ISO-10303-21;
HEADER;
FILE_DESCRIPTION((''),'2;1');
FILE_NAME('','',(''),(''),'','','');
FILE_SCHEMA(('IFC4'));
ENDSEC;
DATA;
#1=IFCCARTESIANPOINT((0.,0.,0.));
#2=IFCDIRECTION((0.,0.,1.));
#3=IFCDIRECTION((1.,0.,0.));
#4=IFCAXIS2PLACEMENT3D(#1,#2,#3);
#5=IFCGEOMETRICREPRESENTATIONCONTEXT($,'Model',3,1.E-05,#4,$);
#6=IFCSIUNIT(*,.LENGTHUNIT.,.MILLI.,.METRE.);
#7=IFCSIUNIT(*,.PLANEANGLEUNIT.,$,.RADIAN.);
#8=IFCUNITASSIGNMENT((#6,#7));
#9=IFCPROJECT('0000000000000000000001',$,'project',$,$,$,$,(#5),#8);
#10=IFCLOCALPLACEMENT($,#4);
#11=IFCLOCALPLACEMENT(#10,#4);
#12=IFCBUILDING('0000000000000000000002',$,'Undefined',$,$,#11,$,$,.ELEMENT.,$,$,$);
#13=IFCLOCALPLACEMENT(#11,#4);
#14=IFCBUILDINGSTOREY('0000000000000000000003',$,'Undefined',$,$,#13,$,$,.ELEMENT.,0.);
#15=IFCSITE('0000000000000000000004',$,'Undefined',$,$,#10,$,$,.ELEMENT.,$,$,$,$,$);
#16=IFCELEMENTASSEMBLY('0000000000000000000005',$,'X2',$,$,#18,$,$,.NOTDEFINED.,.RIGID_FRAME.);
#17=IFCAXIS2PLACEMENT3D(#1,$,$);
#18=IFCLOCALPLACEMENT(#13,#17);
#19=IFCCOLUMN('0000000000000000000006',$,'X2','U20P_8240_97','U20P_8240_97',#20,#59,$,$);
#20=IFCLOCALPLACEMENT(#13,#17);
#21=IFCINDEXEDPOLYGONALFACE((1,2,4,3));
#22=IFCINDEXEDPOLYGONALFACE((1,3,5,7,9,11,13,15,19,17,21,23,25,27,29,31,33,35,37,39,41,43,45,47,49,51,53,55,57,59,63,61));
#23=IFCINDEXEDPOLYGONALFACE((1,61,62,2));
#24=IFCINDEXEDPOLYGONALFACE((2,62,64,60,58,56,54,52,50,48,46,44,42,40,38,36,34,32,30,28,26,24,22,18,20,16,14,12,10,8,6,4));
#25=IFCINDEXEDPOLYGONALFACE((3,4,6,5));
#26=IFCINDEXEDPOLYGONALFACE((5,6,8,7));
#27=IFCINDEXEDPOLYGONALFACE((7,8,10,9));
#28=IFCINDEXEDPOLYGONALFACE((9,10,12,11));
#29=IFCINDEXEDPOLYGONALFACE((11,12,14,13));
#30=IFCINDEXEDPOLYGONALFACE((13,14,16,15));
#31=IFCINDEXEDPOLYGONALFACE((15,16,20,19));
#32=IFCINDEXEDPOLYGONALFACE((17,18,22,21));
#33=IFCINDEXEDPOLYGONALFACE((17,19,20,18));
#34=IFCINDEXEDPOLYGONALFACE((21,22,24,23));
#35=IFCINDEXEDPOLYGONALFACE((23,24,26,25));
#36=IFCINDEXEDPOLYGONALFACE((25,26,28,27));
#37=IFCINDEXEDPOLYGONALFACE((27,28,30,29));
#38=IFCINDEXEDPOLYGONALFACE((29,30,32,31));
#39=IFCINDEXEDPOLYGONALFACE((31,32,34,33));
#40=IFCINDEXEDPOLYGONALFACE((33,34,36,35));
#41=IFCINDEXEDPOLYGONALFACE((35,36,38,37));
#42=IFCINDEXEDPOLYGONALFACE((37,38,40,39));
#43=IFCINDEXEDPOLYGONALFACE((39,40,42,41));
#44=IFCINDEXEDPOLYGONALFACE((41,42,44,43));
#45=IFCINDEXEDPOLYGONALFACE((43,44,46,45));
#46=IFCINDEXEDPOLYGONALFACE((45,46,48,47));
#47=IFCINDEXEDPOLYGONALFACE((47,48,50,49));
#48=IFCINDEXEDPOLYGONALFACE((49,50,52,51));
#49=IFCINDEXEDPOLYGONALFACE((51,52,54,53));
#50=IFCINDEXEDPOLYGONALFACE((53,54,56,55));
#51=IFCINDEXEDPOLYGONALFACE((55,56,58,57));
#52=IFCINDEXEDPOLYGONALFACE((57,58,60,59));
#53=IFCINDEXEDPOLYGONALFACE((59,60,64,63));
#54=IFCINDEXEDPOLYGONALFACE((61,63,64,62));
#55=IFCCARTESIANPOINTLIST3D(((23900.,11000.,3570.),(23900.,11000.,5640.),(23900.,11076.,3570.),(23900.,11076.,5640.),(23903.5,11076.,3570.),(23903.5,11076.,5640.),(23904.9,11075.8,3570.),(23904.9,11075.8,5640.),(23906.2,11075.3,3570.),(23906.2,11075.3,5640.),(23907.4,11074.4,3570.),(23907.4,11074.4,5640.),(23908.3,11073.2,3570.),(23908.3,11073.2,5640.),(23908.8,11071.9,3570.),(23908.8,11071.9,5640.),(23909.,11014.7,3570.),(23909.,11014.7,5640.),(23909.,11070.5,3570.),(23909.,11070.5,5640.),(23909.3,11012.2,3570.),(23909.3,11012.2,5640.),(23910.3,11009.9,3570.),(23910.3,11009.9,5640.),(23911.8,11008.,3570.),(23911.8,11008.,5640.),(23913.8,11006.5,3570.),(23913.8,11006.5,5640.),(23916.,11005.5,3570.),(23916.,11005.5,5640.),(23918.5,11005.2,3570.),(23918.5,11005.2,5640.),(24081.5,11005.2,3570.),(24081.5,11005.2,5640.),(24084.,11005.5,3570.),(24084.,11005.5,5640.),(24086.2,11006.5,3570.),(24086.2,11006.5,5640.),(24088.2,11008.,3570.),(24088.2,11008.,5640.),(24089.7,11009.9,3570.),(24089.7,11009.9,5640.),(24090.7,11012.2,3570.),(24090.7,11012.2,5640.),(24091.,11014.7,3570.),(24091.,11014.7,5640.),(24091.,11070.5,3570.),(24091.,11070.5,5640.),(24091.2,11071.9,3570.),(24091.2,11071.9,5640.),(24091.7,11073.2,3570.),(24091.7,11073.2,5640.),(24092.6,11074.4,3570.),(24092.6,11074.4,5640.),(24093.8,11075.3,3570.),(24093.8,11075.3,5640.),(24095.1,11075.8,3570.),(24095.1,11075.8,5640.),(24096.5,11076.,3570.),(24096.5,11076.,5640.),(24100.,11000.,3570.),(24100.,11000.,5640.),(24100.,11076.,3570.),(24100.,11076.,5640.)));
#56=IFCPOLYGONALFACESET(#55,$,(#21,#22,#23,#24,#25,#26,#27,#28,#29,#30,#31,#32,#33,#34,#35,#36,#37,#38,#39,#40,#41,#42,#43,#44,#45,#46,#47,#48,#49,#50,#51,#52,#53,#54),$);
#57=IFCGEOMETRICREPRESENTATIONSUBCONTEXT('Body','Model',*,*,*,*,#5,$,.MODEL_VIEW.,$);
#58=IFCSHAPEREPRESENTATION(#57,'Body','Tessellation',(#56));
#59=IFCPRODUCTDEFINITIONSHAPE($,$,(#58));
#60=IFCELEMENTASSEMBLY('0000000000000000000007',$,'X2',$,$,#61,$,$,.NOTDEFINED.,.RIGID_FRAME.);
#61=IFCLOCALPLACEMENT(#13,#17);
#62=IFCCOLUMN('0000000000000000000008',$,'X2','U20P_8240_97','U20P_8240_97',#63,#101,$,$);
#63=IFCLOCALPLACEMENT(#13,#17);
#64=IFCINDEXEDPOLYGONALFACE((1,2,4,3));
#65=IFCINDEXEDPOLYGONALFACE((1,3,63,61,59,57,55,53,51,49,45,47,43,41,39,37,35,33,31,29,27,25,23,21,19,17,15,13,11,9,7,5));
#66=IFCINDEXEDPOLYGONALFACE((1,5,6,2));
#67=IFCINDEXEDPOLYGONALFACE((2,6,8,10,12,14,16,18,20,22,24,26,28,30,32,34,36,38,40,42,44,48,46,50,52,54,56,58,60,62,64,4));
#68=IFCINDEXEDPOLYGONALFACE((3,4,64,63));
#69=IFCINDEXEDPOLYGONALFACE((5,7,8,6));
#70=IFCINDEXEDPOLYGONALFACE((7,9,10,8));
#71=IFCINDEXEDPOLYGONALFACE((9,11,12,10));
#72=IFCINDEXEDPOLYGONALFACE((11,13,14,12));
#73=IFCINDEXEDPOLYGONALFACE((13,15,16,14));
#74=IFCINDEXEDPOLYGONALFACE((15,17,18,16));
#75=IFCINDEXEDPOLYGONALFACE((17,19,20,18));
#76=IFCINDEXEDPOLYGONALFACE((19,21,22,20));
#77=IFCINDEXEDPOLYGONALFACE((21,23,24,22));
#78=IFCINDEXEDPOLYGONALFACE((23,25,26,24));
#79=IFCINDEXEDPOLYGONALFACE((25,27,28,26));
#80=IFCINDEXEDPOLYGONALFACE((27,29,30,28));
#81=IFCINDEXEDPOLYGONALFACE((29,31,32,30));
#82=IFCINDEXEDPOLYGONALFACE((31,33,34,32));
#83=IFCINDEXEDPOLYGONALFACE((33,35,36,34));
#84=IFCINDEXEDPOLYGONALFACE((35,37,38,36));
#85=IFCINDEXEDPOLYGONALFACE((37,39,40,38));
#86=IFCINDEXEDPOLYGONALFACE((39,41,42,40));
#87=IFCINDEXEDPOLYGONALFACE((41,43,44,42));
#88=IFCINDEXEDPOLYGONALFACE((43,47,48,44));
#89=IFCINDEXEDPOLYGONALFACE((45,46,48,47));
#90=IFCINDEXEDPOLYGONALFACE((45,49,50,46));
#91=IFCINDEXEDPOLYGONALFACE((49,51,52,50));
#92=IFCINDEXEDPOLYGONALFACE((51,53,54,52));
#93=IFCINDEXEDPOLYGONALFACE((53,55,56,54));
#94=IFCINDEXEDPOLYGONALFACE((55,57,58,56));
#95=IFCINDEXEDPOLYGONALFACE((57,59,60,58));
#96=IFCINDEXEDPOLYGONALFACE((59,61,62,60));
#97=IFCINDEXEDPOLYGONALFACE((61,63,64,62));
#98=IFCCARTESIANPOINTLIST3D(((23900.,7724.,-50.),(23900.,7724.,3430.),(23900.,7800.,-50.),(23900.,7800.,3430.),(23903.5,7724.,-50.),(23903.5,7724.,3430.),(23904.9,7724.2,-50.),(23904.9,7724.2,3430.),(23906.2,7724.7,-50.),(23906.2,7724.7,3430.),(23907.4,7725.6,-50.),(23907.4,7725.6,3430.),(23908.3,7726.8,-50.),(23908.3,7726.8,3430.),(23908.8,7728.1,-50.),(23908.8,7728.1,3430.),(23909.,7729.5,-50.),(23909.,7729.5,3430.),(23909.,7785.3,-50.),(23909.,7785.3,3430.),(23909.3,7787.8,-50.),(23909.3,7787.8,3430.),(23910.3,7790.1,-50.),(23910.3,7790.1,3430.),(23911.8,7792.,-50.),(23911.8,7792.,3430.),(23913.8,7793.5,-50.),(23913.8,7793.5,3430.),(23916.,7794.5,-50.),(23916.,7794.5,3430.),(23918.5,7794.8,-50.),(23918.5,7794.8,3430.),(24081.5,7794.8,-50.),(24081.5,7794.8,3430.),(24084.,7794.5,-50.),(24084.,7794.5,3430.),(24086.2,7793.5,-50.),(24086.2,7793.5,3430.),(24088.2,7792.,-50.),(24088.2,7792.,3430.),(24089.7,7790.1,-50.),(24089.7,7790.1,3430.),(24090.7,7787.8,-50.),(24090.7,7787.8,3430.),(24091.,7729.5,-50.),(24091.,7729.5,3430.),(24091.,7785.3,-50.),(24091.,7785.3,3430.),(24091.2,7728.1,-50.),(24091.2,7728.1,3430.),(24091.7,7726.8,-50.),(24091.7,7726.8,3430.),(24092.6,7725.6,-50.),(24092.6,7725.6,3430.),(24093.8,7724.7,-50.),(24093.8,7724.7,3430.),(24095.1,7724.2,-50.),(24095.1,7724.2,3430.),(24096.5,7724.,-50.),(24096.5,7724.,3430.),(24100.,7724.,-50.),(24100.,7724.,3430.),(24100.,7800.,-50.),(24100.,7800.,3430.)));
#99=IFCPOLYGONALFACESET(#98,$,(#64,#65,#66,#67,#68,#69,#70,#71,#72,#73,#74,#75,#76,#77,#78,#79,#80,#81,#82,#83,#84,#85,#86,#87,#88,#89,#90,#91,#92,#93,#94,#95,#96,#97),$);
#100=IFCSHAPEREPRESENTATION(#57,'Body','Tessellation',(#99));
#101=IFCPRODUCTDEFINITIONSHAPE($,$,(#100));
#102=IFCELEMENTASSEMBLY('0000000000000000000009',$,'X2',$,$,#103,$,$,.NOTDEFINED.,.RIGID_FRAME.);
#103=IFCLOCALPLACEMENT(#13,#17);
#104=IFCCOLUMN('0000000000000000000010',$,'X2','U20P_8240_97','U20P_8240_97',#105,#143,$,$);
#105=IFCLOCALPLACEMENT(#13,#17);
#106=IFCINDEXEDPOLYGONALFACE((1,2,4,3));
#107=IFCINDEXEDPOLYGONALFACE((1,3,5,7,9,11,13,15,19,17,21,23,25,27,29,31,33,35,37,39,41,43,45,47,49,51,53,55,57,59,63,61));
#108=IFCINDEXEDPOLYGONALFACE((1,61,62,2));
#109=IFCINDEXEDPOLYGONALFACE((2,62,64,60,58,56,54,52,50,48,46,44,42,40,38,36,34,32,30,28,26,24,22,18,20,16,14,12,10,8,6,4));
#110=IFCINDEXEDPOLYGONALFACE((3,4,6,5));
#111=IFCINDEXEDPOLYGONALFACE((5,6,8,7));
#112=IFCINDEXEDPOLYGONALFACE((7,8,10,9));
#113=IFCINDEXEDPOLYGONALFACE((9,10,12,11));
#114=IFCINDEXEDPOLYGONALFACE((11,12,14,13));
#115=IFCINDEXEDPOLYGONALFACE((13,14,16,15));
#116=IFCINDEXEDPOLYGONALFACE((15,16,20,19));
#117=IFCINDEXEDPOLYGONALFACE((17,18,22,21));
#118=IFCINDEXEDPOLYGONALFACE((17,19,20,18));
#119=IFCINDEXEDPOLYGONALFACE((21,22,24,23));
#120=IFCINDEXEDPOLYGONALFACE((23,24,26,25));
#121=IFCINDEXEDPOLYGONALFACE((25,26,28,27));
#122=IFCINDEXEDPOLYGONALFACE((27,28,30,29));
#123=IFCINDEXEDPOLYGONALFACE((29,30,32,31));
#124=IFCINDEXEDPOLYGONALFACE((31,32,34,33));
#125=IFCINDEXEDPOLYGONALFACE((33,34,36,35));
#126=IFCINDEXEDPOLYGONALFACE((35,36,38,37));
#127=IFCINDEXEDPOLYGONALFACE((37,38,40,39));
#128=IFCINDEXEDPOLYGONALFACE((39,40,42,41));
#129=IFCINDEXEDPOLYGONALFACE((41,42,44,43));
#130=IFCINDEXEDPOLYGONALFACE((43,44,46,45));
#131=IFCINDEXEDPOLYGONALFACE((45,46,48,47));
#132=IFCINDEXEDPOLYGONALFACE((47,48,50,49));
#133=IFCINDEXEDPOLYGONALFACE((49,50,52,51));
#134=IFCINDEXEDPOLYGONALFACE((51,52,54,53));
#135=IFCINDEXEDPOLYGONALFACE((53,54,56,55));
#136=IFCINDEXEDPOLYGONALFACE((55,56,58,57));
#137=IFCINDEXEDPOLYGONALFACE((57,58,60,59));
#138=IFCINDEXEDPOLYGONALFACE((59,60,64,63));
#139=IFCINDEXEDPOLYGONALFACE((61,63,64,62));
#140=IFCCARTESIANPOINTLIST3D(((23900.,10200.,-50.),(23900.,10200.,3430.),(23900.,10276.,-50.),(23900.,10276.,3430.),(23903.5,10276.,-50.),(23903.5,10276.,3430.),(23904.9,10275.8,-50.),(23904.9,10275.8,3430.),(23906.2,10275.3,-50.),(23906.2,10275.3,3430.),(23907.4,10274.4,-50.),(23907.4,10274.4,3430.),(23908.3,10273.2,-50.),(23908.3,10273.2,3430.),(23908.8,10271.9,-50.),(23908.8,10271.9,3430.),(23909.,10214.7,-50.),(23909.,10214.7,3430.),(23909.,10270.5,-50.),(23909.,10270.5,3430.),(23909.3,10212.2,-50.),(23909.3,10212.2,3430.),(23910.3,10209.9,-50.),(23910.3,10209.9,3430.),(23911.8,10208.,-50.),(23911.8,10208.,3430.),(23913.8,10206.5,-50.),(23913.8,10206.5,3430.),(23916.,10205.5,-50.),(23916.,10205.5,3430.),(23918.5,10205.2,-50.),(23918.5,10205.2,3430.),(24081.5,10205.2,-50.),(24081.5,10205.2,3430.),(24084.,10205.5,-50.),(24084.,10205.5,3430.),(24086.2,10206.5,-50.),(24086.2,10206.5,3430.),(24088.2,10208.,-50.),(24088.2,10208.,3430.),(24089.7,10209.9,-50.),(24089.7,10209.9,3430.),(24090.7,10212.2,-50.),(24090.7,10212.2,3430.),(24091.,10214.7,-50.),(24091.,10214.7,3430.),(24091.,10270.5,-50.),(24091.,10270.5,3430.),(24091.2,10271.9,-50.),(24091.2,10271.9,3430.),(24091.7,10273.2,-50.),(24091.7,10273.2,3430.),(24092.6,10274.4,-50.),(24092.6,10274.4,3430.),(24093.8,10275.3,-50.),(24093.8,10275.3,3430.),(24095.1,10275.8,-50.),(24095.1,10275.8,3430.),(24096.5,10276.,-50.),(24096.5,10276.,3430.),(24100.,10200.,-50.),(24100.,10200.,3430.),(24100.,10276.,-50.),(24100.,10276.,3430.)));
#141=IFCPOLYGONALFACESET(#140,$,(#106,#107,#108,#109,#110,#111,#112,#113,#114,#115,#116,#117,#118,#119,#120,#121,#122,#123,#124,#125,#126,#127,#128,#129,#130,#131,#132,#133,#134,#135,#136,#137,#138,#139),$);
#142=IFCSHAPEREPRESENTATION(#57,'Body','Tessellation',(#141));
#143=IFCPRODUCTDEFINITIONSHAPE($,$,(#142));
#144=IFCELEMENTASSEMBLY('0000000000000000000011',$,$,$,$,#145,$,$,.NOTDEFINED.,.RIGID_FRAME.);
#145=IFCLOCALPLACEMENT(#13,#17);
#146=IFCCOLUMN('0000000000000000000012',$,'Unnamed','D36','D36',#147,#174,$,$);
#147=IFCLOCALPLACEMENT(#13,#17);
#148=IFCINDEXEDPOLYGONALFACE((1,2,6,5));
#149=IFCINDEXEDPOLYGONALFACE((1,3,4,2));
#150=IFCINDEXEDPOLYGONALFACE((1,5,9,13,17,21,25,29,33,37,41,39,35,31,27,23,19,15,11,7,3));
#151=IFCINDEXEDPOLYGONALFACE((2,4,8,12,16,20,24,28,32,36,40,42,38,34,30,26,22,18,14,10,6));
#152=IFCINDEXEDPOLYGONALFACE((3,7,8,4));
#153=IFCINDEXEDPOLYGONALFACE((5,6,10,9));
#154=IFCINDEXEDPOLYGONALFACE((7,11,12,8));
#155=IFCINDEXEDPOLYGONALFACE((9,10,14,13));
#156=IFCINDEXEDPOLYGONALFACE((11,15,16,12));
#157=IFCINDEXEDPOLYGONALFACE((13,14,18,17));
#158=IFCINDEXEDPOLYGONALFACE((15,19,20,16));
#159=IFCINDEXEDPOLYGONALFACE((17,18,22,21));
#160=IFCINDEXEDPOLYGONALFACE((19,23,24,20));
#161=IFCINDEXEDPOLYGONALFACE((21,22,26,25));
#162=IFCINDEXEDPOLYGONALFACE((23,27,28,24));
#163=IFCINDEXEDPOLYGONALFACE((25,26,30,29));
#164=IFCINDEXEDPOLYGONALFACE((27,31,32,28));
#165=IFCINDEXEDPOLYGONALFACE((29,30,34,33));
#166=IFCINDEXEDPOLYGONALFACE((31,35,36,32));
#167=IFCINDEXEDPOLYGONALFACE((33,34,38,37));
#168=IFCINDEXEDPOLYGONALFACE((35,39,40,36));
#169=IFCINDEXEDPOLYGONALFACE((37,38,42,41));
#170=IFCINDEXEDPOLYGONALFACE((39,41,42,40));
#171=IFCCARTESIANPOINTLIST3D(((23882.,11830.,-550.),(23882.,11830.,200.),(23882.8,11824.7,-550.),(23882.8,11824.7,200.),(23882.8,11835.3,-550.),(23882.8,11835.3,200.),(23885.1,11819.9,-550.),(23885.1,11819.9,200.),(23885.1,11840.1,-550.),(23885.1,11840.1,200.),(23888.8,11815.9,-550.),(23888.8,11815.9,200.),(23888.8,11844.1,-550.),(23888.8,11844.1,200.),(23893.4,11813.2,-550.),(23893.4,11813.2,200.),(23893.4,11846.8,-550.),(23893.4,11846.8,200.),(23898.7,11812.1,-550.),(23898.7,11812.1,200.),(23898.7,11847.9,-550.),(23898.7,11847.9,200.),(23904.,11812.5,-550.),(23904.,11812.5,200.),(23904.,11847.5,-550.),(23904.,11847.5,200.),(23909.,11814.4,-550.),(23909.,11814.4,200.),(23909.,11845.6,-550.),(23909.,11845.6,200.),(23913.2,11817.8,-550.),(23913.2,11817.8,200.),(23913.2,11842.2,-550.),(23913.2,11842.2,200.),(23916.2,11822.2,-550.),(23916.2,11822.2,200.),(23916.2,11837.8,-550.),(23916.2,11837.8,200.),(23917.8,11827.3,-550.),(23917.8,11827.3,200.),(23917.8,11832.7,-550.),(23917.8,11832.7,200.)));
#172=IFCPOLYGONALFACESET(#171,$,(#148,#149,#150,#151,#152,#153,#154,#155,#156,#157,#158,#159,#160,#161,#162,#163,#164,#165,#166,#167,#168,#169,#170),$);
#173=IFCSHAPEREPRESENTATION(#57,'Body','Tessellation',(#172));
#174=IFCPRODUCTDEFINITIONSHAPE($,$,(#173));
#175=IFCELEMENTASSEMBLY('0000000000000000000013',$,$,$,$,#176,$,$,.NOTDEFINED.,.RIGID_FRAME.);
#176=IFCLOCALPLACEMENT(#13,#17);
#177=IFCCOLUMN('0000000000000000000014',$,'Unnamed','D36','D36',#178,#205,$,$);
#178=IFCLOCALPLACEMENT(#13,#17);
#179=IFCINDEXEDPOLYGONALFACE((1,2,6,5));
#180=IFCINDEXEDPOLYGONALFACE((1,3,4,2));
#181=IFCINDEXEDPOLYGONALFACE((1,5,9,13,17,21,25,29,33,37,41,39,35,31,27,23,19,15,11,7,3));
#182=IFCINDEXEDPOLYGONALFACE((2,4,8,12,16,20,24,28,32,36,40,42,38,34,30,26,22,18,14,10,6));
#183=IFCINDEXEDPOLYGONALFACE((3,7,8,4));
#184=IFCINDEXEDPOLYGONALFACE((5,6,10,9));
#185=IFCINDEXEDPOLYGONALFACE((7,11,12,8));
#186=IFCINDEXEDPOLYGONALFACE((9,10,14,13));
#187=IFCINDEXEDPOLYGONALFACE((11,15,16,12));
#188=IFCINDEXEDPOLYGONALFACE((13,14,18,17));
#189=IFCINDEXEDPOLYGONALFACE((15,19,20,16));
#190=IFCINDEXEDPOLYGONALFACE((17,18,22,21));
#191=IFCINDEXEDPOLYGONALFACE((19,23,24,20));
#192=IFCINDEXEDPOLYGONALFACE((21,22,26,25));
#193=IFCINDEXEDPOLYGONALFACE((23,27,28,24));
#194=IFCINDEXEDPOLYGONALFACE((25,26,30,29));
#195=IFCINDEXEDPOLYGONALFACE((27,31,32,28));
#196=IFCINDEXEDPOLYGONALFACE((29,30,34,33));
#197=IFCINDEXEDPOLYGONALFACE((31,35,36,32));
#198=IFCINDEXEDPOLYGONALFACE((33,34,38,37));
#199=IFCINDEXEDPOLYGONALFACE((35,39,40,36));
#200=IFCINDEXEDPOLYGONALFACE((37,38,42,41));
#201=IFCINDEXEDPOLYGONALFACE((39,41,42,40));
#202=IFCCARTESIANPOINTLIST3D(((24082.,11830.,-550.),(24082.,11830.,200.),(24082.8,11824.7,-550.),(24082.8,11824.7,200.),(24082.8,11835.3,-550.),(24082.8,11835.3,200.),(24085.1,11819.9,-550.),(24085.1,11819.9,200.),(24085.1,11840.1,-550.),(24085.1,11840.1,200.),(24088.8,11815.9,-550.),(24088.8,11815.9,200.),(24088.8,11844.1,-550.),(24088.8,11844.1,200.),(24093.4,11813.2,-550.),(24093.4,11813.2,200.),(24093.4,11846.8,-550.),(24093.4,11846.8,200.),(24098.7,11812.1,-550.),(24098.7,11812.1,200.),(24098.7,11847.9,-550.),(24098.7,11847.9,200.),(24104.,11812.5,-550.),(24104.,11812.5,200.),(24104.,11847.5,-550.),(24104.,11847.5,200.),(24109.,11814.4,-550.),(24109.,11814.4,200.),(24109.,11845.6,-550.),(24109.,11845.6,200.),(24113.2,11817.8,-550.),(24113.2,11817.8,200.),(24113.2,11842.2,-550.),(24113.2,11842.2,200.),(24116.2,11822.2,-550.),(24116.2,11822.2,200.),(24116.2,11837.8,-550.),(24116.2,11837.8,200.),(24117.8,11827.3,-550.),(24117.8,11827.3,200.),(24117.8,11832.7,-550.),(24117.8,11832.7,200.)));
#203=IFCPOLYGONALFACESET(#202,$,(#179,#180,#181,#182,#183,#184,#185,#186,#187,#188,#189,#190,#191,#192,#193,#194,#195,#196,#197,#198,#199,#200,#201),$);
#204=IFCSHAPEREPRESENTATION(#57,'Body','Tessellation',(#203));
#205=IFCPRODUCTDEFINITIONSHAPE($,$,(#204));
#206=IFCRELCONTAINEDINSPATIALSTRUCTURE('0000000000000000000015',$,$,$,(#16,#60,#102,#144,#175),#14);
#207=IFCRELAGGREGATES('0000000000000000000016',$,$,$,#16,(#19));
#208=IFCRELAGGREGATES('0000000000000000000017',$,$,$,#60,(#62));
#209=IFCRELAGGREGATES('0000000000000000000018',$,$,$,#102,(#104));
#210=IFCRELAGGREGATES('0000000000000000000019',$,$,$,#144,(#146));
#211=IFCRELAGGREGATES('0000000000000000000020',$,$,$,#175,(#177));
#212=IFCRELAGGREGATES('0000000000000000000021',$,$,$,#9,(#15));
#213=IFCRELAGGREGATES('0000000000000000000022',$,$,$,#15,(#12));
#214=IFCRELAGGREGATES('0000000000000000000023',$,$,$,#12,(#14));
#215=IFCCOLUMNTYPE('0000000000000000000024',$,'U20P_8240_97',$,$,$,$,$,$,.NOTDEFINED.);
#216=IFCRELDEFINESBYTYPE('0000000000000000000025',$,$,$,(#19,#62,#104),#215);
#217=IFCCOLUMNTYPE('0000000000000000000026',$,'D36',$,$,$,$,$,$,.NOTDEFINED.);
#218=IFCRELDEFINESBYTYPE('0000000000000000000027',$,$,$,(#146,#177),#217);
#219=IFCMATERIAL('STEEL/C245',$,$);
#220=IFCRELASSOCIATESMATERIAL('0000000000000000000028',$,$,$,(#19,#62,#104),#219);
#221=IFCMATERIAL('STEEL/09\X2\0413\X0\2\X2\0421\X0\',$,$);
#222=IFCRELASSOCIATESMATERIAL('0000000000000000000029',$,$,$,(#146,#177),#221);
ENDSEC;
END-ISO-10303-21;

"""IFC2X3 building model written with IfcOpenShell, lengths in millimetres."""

from ifc_helpers import new_model, si_unit, frame, origin_with_axes, origin_2d_with_axis, place, context, subcontext, project, spatial, circle, u_section, extrude, material, type_object, element, aggregate, save


model = new_model("IFC2X3")

# Units and contexts
model_context = context("Model", 3, precision=1e-05, world=origin_with_axes())
body_context = subcontext(model_context, "Body", "Model", "MODEL_VIEW")
ifc_project = project(units=[si_unit("LENGTHUNIT", "METRE", prefix="MILLI"), si_unit("PLANEANGLEUNIT", "RADIAN")], contexts=[model_context])

# Site, building, storey
site_placement = place(None, origin_with_axes())
site = spatial("IfcSite", under=ifc_project, at=site_placement, Name="Undefined", CompositionType="ELEMENT")
building_placement = place(site_placement, origin_with_axes())
building = spatial("IfcBuilding", under=site, at=building_placement, Name="Undefined", CompositionType="ELEMENT")
storey_placement = place(building_placement, origin_with_axes())
storey = spatial("IfcBuildingStorey", under=building, at=storey_placement, Name="Undefined", CompositionType="ELEMENT", Elevation=0.0)

# Element assemblies, columns
assembly_1_placement = place(storey_placement, origin_with_axes())
assembly_1 = element("IfcElementAssembly", 1, at=assembly_1_placement, inside=storey, Name="X2", AssemblyPlace="NOTDEFINED", PredefinedType="RIGID_FRAME")
ifc_material_1 = material(Name="STEEL/C245")
column_type_1 = type_object("IfcColumnType", Name="U20P_8240_97", PredefinedType="NOTDEFINED")
column_1_placement = place(assembly_1_placement, frame((24000.0, 11038.0, 3570.0), z_axis=(0.0, 0.0, 1.0), x_axis=(1.0, 0.0, 0.0)))
column_1 = element("IfcColumn", 2, at=column_1_placement, type_object=column_type_1, material=ifc_material_1, Name="X2", Description="U20P_8240_97", ObjectType="U20P_8240_97", context=body_context, shape_type="SweptSolid", body=[
    extrude(u_section(Depth=200.0, FlangeWidth=76.0, WebThickness=5.2, FlangeThickness=9.0, FilletRadius=9.5, EdgeRadius=5.5, at=origin_2d_with_axis()), frame((0.0, 0.0, 2070.0), z_axis=(0.0, 0.0, -1.0), x_axis=(0.0, 1.0, 0.0)), (0.0, 0.0, 1.0), 2070.0),
])
aggregate(assembly_1, [column_1])
assembly_2_placement = place(storey_placement, origin_with_axes())
assembly_2 = element("IfcElementAssembly", 3, at=assembly_2_placement, inside=storey, Name="X2", AssemblyPlace="NOTDEFINED", PredefinedType="RIGID_FRAME")
column_2_placement = place(assembly_2_placement, frame((24000.0, 7762.0, -50.0), z_axis=(0.0, 0.0, 1.0), x_axis=(-1.0, 0.0, 0.0)))
column_2 = element("IfcColumn", 4, at=column_2_placement, type_object=column_type_1, material=ifc_material_1, Name="X2", Description="U20P_8240_97", ObjectType="U20P_8240_97", context=body_context, shape_type="SweptSolid", body=[
    extrude(u_section(Depth=200.0, FlangeWidth=76.0, WebThickness=5.2, FlangeThickness=9.0, FilletRadius=9.5, EdgeRadius=5.5, at=origin_2d_with_axis()), frame((0.0, 0.0, 3480.0), z_axis=(0.0, 0.0, -1.0), x_axis=(0.0, 1.0, 0.0)), (0.0, 0.0, 1.0), 3480.0),
])
aggregate(assembly_2, [column_2])
assembly_3_placement = place(storey_placement, origin_with_axes())
assembly_3 = element("IfcElementAssembly", 5, at=assembly_3_placement, inside=storey, Name="X2", AssemblyPlace="NOTDEFINED", PredefinedType="RIGID_FRAME")
column_3_placement = place(assembly_3_placement, frame((24000.0, 10238.0, -50.0), z_axis=(0.0, 0.0, 1.0), x_axis=(1.0, 0.0, 0.0)))
column_3 = element("IfcColumn", 6, at=column_3_placement, type_object=column_type_1, material=ifc_material_1, Name="X2", Description="U20P_8240_97", ObjectType="U20P_8240_97", context=body_context, shape_type="SweptSolid", body=[
    extrude(u_section(Depth=200.0, FlangeWidth=76.0, WebThickness=5.2, FlangeThickness=9.0, FilletRadius=9.5, EdgeRadius=5.5, at=origin_2d_with_axis()), frame((0.0, 0.0, 3480.0), z_axis=(0.0, 0.0, -1.0), x_axis=(0.0, 1.0, 0.0)), (0.0, 0.0, 1.0), 3480.0),
])
aggregate(assembly_3, [column_3])
assembly_4_placement = place(storey_placement, origin_with_axes())
assembly_4 = element("IfcElementAssembly", 7, at=assembly_4_placement, inside=storey, AssemblyPlace="NOTDEFINED", PredefinedType="RIGID_FRAME")
ifc_material_2 = material(Name="STEEL/09Г2С")
column_type_2 = type_object("IfcColumnType", Name="D36", PredefinedType="NOTDEFINED")
column_4_placement = place(assembly_4_placement, frame((23900.0, 11830.0, -550.0), z_axis=(0.0, 0.0, 1.0), x_axis=(0.0, 1.0, 0.0)))
column_4 = element("IfcColumn", 8, at=column_4_placement, type_object=column_type_2, material=ifc_material_2, Name="Unnamed", Description="D36", ObjectType="D36", context=body_context, shape_type="SweptSolid", body=[
    extrude(circle(Radius=18.0, at=origin_2d_with_axis()), frame((0.0, 0.0, 750.0), z_axis=(0.0, 0.0, -1.0), x_axis=(0.0, 1.0, 0.0)), (0.0, 0.0, 1.0), 750.0),
])
aggregate(assembly_4, [column_4])
assembly_5_placement = place(storey_placement, origin_with_axes())
assembly_5 = element("IfcElementAssembly", 9, at=assembly_5_placement, inside=storey, AssemblyPlace="NOTDEFINED", PredefinedType="RIGID_FRAME")
column_5_placement = place(assembly_5_placement, frame((24100.0, 11830.0, -550.0), z_axis=(0.0, 0.0, 1.0), x_axis=(0.0, 1.0, 0.0)))
column_5 = element("IfcColumn", 10, at=column_5_placement, type_object=column_type_2, material=ifc_material_2, Name="Unnamed", Description="D36", ObjectType="D36", context=body_context, shape_type="SweptSolid", body=[
    extrude(circle(Radius=18.0, at=origin_2d_with_axis()), frame((0.0, 0.0, 750.0), z_axis=(0.0, 0.0, -1.0), x_axis=(0.0, 1.0, 0.0)), (0.0, 0.0, 1.0), 750.0),
])
aggregate(assembly_5, [column_5])

save(model, "model.ifc")
